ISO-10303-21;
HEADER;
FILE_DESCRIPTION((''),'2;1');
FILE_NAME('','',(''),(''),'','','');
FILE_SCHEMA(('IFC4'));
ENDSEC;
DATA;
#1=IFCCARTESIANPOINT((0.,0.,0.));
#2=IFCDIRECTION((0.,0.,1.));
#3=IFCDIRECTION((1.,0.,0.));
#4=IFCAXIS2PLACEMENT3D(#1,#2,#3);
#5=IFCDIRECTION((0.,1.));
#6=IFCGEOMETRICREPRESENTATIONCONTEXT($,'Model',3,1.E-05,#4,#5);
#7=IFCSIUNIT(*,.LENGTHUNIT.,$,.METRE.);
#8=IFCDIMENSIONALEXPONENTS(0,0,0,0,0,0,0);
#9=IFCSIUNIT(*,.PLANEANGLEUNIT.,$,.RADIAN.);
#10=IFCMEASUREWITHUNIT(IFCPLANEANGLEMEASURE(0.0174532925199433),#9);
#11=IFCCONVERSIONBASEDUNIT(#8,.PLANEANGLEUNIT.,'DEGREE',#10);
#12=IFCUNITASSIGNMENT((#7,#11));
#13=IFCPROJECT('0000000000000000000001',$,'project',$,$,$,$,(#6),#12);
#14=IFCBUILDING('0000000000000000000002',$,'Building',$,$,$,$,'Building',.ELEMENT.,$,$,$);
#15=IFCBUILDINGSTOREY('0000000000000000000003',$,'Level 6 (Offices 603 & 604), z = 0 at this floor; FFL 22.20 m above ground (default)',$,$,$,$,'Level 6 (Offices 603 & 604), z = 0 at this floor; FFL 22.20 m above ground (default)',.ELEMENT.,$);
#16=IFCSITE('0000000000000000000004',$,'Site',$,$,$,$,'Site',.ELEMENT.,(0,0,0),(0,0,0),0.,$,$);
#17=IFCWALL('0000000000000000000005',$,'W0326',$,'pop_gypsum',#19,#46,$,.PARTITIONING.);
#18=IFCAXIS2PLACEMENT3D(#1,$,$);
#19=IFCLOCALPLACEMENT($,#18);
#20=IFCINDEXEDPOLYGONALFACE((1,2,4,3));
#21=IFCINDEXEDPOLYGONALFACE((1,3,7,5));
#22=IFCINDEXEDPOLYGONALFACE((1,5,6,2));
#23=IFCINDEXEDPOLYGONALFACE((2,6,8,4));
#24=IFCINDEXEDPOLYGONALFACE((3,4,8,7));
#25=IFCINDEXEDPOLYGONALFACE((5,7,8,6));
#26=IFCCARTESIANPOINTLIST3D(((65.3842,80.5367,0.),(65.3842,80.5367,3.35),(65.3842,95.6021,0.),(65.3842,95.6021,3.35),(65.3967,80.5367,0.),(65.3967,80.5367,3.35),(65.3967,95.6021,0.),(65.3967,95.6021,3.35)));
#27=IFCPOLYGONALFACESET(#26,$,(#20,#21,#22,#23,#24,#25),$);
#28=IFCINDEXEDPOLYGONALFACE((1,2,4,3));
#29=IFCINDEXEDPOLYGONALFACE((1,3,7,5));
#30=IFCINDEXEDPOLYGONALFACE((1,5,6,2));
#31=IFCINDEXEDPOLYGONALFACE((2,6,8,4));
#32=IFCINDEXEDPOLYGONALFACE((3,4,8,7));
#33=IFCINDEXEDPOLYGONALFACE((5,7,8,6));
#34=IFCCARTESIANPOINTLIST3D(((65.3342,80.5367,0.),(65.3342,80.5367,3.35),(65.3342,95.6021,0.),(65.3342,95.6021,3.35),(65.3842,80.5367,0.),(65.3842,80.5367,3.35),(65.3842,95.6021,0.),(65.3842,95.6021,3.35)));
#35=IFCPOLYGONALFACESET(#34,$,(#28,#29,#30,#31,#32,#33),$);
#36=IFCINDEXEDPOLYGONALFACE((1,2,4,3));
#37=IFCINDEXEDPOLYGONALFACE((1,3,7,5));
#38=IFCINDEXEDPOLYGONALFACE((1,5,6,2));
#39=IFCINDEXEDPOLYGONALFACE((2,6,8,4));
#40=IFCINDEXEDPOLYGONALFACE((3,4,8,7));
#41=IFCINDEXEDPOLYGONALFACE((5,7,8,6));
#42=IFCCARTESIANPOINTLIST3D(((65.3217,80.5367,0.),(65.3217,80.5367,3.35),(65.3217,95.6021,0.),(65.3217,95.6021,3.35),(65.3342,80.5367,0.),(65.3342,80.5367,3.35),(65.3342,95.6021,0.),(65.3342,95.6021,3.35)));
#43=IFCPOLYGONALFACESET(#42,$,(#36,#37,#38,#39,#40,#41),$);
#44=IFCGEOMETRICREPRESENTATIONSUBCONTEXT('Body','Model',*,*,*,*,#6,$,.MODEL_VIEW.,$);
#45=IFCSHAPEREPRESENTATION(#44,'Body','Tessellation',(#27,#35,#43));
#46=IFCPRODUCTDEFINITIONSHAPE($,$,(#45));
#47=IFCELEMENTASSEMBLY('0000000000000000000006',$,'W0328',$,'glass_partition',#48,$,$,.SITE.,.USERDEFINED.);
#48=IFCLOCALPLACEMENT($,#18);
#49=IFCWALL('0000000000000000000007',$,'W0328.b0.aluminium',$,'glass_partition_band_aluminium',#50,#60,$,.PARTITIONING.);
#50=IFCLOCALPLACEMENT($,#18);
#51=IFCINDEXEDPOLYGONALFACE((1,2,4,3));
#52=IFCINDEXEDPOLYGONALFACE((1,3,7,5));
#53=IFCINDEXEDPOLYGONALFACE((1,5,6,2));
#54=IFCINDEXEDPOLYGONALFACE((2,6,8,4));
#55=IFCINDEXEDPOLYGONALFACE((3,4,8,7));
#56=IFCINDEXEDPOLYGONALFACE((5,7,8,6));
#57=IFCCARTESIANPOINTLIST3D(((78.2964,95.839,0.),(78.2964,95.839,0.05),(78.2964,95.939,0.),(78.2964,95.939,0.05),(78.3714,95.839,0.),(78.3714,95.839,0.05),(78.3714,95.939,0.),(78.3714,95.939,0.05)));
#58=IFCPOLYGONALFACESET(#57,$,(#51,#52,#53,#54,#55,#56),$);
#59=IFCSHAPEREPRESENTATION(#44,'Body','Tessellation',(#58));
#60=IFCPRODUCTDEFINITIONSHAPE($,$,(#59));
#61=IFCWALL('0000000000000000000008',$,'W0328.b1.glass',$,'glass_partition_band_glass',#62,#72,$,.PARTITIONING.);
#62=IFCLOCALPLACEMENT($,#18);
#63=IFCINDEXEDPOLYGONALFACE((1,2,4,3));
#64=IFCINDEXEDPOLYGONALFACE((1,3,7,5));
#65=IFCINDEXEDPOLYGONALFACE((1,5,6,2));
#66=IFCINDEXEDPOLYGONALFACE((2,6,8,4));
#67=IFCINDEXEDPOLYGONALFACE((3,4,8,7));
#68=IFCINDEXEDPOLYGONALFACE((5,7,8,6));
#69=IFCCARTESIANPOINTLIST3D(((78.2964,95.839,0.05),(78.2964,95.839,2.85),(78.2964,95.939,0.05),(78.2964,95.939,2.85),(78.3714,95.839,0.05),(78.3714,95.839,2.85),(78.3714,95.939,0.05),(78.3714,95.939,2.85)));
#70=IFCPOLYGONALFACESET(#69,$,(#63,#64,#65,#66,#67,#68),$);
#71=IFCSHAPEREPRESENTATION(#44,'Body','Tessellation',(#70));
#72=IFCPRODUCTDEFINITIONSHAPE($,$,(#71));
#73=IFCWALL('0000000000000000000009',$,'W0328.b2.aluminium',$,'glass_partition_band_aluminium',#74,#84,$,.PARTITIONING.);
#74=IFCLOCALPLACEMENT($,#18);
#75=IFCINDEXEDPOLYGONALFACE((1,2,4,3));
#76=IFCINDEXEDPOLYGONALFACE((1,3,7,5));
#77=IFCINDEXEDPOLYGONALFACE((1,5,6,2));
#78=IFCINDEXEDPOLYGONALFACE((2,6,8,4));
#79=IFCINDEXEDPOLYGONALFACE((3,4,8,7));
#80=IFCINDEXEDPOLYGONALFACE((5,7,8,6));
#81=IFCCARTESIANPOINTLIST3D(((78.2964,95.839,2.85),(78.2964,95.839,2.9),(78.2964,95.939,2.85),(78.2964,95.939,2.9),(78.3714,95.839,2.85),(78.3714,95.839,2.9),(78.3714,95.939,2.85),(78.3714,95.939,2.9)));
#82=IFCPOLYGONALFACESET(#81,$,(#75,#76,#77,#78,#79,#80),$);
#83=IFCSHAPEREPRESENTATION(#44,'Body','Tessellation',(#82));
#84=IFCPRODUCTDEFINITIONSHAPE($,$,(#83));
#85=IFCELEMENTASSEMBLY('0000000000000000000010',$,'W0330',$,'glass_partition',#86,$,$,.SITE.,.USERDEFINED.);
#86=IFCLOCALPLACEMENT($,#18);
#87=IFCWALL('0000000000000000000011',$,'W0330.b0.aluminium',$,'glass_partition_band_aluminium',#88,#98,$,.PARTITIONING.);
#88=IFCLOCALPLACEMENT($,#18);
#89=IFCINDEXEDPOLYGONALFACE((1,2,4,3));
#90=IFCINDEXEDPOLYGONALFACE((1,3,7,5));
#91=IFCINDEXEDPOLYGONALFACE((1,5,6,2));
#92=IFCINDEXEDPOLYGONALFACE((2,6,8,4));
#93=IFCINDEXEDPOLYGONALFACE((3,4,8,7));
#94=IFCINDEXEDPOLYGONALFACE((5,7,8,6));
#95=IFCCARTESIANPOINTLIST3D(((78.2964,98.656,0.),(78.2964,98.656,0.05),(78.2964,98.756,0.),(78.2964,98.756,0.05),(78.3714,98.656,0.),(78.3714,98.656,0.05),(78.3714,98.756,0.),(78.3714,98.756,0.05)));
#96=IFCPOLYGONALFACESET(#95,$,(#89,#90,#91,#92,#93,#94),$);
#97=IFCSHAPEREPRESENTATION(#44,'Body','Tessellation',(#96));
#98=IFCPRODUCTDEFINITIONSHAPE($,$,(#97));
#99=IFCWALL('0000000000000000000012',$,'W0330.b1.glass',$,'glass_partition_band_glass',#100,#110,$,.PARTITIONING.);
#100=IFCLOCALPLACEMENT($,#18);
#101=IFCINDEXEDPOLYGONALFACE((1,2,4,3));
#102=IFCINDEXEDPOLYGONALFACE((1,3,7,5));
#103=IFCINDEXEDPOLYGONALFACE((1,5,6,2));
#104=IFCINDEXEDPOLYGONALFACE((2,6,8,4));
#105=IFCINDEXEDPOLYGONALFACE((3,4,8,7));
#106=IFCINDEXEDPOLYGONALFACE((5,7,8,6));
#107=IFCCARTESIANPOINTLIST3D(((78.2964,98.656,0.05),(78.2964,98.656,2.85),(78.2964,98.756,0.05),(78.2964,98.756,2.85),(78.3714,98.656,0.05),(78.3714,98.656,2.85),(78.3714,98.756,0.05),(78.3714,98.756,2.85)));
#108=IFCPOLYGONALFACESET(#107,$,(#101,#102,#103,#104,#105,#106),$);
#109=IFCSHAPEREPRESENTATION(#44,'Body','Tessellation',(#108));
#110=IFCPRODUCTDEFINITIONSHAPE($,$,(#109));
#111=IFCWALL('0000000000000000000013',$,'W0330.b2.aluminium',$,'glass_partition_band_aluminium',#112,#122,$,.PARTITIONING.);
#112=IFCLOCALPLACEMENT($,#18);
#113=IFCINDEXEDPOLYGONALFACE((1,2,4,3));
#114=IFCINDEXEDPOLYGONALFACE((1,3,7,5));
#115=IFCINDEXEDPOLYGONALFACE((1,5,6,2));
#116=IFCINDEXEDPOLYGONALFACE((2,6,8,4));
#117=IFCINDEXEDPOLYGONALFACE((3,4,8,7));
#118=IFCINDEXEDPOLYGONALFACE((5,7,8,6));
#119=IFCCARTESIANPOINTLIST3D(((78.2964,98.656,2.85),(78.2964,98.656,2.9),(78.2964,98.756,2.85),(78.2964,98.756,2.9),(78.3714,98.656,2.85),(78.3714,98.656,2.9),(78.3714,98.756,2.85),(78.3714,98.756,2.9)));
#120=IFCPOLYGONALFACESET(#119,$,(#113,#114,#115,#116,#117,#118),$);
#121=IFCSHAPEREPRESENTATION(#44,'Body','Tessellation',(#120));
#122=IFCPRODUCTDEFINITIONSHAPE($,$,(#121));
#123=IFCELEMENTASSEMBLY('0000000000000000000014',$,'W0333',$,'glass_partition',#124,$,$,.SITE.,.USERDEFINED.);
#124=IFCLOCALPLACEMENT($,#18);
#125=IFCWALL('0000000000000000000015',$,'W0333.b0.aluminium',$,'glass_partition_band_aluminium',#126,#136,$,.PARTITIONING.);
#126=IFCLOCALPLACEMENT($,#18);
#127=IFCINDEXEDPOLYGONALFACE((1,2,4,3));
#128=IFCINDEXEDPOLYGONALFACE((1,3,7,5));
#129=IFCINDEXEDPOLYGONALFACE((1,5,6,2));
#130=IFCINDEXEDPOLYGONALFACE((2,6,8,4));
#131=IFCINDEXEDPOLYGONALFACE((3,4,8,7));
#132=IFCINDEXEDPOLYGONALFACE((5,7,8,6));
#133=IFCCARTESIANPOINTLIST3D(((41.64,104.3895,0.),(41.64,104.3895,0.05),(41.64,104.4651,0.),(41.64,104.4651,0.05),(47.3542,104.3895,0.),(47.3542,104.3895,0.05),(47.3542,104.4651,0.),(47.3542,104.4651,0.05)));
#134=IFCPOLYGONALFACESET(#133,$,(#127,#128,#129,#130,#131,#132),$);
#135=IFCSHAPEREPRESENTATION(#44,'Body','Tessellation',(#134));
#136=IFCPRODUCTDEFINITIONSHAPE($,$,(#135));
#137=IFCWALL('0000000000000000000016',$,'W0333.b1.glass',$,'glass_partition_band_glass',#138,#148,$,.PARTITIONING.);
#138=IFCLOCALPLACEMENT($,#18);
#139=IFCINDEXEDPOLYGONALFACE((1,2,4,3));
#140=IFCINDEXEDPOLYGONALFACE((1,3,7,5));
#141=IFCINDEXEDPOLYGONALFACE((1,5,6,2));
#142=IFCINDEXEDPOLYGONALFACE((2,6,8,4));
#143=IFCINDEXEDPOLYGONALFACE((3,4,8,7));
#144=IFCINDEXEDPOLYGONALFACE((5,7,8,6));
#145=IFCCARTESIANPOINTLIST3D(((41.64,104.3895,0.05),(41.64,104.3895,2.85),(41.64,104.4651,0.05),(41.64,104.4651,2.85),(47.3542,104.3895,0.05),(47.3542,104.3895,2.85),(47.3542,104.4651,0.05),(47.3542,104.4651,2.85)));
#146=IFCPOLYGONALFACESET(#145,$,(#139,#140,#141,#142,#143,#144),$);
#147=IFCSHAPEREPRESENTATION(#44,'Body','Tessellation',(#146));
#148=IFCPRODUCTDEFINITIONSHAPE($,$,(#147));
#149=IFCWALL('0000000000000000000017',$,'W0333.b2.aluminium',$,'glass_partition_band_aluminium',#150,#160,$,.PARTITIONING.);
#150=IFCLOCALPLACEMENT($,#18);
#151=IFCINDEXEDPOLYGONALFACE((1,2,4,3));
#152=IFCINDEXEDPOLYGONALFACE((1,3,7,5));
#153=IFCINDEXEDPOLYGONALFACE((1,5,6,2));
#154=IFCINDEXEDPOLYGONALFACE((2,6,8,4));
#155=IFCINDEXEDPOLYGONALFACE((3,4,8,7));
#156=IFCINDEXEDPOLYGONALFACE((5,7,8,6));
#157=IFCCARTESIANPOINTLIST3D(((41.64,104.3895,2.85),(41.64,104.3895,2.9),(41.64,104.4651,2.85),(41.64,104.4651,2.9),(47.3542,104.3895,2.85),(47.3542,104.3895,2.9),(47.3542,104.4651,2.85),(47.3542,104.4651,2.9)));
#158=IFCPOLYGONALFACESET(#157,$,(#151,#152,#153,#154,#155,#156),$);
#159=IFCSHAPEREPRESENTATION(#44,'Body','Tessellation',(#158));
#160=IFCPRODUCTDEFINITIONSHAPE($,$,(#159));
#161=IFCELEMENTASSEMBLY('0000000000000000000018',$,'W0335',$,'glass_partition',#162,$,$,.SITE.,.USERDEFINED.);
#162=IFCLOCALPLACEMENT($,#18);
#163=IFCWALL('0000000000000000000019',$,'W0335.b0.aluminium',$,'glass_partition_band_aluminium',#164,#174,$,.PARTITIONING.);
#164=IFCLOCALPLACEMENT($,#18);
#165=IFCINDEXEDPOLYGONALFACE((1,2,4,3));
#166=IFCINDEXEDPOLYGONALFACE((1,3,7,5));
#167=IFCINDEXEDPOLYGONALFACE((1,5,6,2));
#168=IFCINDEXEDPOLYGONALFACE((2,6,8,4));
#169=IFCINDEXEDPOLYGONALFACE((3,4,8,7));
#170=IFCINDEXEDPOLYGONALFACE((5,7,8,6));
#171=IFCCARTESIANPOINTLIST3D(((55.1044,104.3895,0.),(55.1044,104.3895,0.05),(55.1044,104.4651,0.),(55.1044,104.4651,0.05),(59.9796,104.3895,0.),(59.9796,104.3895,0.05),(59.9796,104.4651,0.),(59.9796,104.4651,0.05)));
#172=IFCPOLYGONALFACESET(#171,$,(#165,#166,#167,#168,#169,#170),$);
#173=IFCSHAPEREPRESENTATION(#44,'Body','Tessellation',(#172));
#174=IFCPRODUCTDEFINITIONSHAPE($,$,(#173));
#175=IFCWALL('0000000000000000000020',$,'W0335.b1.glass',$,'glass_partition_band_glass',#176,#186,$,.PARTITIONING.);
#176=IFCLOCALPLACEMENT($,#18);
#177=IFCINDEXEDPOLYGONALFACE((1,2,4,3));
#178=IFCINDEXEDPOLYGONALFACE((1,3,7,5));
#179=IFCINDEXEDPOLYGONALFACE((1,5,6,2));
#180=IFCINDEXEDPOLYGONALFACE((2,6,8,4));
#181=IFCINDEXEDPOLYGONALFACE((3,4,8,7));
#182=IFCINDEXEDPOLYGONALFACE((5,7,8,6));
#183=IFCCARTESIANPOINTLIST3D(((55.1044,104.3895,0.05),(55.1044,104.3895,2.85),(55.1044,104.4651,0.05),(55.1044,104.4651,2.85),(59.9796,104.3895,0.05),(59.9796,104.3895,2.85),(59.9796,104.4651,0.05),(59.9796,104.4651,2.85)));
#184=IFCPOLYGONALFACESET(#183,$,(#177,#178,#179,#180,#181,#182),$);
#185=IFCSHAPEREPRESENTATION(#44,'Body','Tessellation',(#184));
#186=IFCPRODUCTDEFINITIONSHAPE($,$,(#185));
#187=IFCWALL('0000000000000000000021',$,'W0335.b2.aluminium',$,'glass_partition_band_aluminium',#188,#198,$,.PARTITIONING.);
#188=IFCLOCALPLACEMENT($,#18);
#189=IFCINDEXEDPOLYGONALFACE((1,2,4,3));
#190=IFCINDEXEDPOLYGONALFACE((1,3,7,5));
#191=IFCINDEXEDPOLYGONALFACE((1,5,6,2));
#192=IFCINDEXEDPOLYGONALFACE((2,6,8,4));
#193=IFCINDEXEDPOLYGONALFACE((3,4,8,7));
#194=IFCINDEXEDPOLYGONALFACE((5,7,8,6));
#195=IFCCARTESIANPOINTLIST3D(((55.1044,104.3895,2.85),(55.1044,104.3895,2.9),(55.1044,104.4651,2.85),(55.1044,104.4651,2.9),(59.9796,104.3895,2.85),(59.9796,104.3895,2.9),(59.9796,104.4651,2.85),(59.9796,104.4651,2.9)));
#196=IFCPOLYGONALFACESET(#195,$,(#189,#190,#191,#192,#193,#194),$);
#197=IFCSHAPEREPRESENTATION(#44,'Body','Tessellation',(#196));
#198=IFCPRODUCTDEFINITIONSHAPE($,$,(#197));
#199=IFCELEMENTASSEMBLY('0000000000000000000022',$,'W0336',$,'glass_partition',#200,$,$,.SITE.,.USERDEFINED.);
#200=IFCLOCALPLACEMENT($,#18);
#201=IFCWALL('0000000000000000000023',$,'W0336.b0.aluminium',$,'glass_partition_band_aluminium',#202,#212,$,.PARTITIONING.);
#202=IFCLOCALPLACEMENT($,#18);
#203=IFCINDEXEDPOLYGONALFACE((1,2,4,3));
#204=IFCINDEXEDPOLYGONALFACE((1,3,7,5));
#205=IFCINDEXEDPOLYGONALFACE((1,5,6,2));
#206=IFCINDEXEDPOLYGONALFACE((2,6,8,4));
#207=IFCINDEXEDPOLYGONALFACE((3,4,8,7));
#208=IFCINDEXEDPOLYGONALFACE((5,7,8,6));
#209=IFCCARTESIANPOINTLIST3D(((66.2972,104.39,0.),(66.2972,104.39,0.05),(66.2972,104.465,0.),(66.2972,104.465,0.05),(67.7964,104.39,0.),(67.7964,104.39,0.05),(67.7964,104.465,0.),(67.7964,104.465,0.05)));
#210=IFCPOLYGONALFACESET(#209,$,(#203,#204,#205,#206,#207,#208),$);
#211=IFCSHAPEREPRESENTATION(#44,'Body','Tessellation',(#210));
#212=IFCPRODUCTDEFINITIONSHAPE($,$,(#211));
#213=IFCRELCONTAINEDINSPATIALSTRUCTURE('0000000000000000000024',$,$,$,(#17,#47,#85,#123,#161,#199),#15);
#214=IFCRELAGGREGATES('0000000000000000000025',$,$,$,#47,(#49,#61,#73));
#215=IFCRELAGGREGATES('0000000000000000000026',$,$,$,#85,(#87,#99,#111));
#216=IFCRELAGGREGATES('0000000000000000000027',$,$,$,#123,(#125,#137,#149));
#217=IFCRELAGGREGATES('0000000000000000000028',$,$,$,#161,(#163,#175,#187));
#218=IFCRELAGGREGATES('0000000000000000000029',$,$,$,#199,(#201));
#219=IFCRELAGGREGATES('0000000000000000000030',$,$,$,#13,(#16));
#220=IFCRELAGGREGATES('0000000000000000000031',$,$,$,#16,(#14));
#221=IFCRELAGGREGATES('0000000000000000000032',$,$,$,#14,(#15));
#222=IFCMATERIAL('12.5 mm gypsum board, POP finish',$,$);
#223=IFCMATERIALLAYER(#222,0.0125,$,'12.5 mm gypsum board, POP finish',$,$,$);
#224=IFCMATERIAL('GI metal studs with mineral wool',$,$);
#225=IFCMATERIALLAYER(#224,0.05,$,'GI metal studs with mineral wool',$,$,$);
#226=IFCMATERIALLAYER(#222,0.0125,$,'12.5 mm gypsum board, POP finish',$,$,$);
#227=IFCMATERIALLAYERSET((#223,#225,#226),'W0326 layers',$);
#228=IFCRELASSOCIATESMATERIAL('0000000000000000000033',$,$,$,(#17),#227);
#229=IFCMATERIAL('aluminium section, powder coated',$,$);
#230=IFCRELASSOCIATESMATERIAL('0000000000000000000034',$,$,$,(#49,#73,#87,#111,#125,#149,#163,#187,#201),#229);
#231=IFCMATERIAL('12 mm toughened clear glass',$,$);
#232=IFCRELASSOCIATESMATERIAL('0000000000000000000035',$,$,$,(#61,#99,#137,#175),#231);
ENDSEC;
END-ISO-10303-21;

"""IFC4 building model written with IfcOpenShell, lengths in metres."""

from ifc_helpers import new_model, entity, si_unit, converted_unit, direction, frame, frame_2d, origin_with_axes, place, context, subcontext, project, spatial, rectangle, extrude, material, layer, layer_set, layer_usage, element, aggregate, save


model = new_model("IFC4")

# Units and contexts
model_context = context("Model", 3, precision=1e-05, world=origin_with_axes(), true_north=direction((0.0, 1.0)))
body_context = subcontext(model_context, "Body", "Model", "MODEL_VIEW")
ifc_project = project(units=[si_unit("LENGTHUNIT", "METRE"), converted_unit("PLANEANGLEUNIT", "DEGREE", entity("IfcPlaneAngleMeasure", 0.0174532925199433), si_unit("PLANEANGLEUNIT", "RADIAN"), dimensions=[0, 0, 0, 0, 0, 0, 0])], contexts=[model_context])

# Site, building, storey
site = spatial("IfcSite", under=ifc_project, Name="Site", LongName="Site", CompositionType="ELEMENT", RefLatitude=(0, 0, 0), RefLongitude=(0, 0, 0), RefElevation=0.0)
building = spatial("IfcBuilding", under=site, Name="Building", LongName="Building", CompositionType="ELEMENT")
storey = spatial("IfcBuildingStorey", under=building, Name="Level 6 (Offices 603 & 604), z = 0 at this floor; FFL 22.20 m above ground (default)", LongName="Level 6 (Offices 603 & 604), z = 0 at this floor; FFL 22.20 m above ground (default)", CompositionType="ELEMENT")

# Wall
placement = place(None, origin_with_axes())
ifc_material_1 = material(Name="12.5 mm gypsum board, POP finish")
ifc_material_2 = material(Name="GI metal studs with mineral wool")
ifc_layer_1 = layer(ifc_material_1, 0.0125, Name="12.5 mm gypsum board, POP finish")
ifc_layer_2 = layer(ifc_material_2, 0.05, Name="GI metal studs with mineral wool")
ifc_layer_3 = layer(ifc_material_1, 0.0125, Name="12.5 mm gypsum board, POP finish")
ifc_layer_set_1 = layer_set([ifc_layer_1, ifc_layer_2, ifc_layer_3], Name="W0326 layers")
ifc_layer_usage_1 = layer_usage(ifc_layer_set_1, "AXIS2", "POSITIVE", -0.0375)
element("IfcWall", 1, at=placement, inside=storey, material=ifc_layer_usage_1, Name="W0326", ObjectType="pop_gypsum", PredefinedType="PARTITIONING", context=body_context, shape_type="SweptSolid", body=[
    extrude(rectangle(XDim=15.0654, YDim=0.0125, at=frame_2d((0.0, 0.0), x_axis=(0.0, 1.0))), frame((65.3905, 88.0694, 0.0), z_axis=(0.0, 0.0, 1.0), x_axis=(1.0, 0.0, 0.0)), (0.0, 0.0, 1.0), 3.35),
    extrude(rectangle(XDim=15.0654, YDim=0.05, at=frame_2d((-0.0312, 0.0), x_axis=(0.0, 1.0))), frame((65.3905, 88.0694, 0.0), z_axis=(0.0, 0.0, 1.0), x_axis=(1.0, 0.0, 0.0)), (0.0, 0.0, 1.0), 3.35),
    extrude(rectangle(XDim=15.0654, YDim=0.0125, at=frame_2d((-0.0625, 0.0), x_axis=(0.0, 1.0))), frame((65.3905, 88.0694, 0.0), z_axis=(0.0, 0.0, 1.0), x_axis=(1.0, 0.0, 0.0)), (0.0, 0.0, 1.0), 3.35),
])

# Element assemblies, walls
assembly_1 = element("IfcElementAssembly", 2, inside=storey, Name="W0328", ObjectType="glass_partition", AssemblyPlace="SITE", PredefinedType="USERDEFINED")
ifc_material_3 = material(Name="aluminium section, powder coated")
wall_1 = element("IfcWall", 3, at=placement, material=ifc_material_3, Name="W0328.b0.aluminium", ObjectType="glass_partition_band_aluminium", PredefinedType="PARTITIONING", context=body_context, shape_type="SweptSolid", body=[
    extrude(rectangle(XDim=0.1, YDim=0.075, at=frame_2d((0.0, 0.0), x_axis=(0.0, 1.0))), frame((78.3339, 95.889, 0.0), z_axis=(0.0, 0.0, 1.0), x_axis=(1.0, 0.0, 0.0)), (0.0, 0.0, 1.0), 0.05),
])
ifc_material_4 = material(Name="12 mm toughened clear glass")
wall_2 = element("IfcWall", 4, at=placement, material=ifc_material_4, Name="W0328.b1.glass", ObjectType="glass_partition_band_glass", PredefinedType="PARTITIONING", context=body_context, shape_type="SweptSolid", body=[
    extrude(rectangle(XDim=0.1, YDim=0.075, at=frame_2d((0.0, 0.0), x_axis=(0.0, 1.0))), frame((78.3339, 95.889, 0.05), z_axis=(0.0, 0.0, 1.0), x_axis=(1.0, 0.0, 0.0)), (0.0, 0.0, 1.0), 2.8),
])
wall_3 = element("IfcWall", 5, at=placement, material=ifc_material_3, Name="W0328.b2.aluminium", ObjectType="glass_partition_band_aluminium", PredefinedType="PARTITIONING", context=body_context, shape_type="SweptSolid", body=[
    extrude(rectangle(XDim=0.1, YDim=0.075, at=frame_2d((0.0, 0.0), x_axis=(0.0, 1.0))), frame((78.3339, 95.889, 2.85), z_axis=(0.0, 0.0, 1.0), x_axis=(1.0, 0.0, 0.0)), (0.0, 0.0, 1.0), 0.05),
])
aggregate(assembly_1, [wall_1, wall_2, wall_3])
assembly_2 = element("IfcElementAssembly", 6, inside=storey, Name="W0330", ObjectType="glass_partition", AssemblyPlace="SITE", PredefinedType="USERDEFINED")
wall_4 = element("IfcWall", 7, at=placement, material=ifc_material_3, Name="W0330.b0.aluminium", ObjectType="glass_partition_band_aluminium", PredefinedType="PARTITIONING", context=body_context, shape_type="SweptSolid", body=[
    extrude(rectangle(XDim=0.1, YDim=0.075, at=frame_2d((0.0, 0.0), x_axis=(0.0, 1.0))), frame((78.3339, 98.706, 0.0), z_axis=(0.0, 0.0, 1.0), x_axis=(1.0, 0.0, 0.0)), (0.0, 0.0, 1.0), 0.05),
])
wall_5 = element("IfcWall", 8, at=placement, material=ifc_material_4, Name="W0330.b1.glass", ObjectType="glass_partition_band_glass", PredefinedType="PARTITIONING", context=body_context, shape_type="SweptSolid", body=[
    extrude(rectangle(XDim=0.1, YDim=0.075, at=frame_2d((0.0, 0.0), x_axis=(0.0, 1.0))), frame((78.3339, 98.706, 0.05), z_axis=(0.0, 0.0, 1.0), x_axis=(1.0, 0.0, 0.0)), (0.0, 0.0, 1.0), 2.8),
])
wall_6 = element("IfcWall", 9, at=placement, material=ifc_material_3, Name="W0330.b2.aluminium", ObjectType="glass_partition_band_aluminium", PredefinedType="PARTITIONING", context=body_context, shape_type="SweptSolid", body=[
    extrude(rectangle(XDim=0.1, YDim=0.075, at=frame_2d((0.0, 0.0), x_axis=(0.0, 1.0))), frame((78.3339, 98.706, 2.85), z_axis=(0.0, 0.0, 1.0), x_axis=(1.0, 0.0, 0.0)), (0.0, 0.0, 1.0), 0.05),
])
aggregate(assembly_2, [wall_4, wall_5, wall_6])
assembly_3 = element("IfcElementAssembly", 10, inside=storey, Name="W0333", ObjectType="glass_partition", AssemblyPlace="SITE", PredefinedType="USERDEFINED")
wall_7 = element("IfcWall", 11, at=placement, material=ifc_material_3, Name="W0333.b0.aluminium", ObjectType="glass_partition_band_aluminium", PredefinedType="PARTITIONING", context=body_context, shape_type="SweptSolid", body=[
    extrude(rectangle(XDim=5.7142, YDim=0.0756, at=frame_2d((0.0, 0.0), x_axis=(1.0, 0.0))), frame((44.4971, 104.4273, 0.0), z_axis=(0.0, 0.0, 1.0), x_axis=(1.0, 0.0, 0.0)), (0.0, 0.0, 1.0), 0.05),
])
wall_8 = element("IfcWall", 12, at=placement, material=ifc_material_4, Name="W0333.b1.glass", ObjectType="glass_partition_band_glass", PredefinedType="PARTITIONING", context=body_context, shape_type="SweptSolid", body=[
    extrude(rectangle(XDim=5.7142, YDim=0.0756, at=frame_2d((0.0, 0.0), x_axis=(1.0, 0.0))), frame((44.4971, 104.4273, 0.05), z_axis=(0.0, 0.0, 1.0), x_axis=(1.0, 0.0, 0.0)), (0.0, 0.0, 1.0), 2.8),
])
wall_9 = element("IfcWall", 13, at=placement, material=ifc_material_3, Name="W0333.b2.aluminium", ObjectType="glass_partition_band_aluminium", PredefinedType="PARTITIONING", context=body_context, shape_type="SweptSolid", body=[
    extrude(rectangle(XDim=5.7142, YDim=0.0756, at=frame_2d((0.0, 0.0), x_axis=(1.0, 0.0))), frame((44.4971, 104.4273, 2.85), z_axis=(0.0, 0.0, 1.0), x_axis=(1.0, 0.0, 0.0)), (0.0, 0.0, 1.0), 0.05),
])
aggregate(assembly_3, [wall_7, wall_8, wall_9])
assembly_4 = element("IfcElementAssembly", 14, inside=storey, Name="W0335", ObjectType="glass_partition", AssemblyPlace="SITE", PredefinedType="USERDEFINED")
wall_10 = element("IfcWall", 15, at=placement, material=ifc_material_3, Name="W0335.b0.aluminium", ObjectType="glass_partition_band_aluminium", PredefinedType="PARTITIONING", context=body_context, shape_type="SweptSolid", body=[
    extrude(rectangle(XDim=4.8752, YDim=0.0756, at=frame_2d((0.0, 0.0), x_axis=(1.0, 0.0))), frame((57.542, 104.4273, 0.0), z_axis=(0.0, 0.0, 1.0), x_axis=(1.0, 0.0, 0.0)), (0.0, 0.0, 1.0), 0.05),
])
wall_11 = element("IfcWall", 16, at=placement, material=ifc_material_4, Name="W0335.b1.glass", ObjectType="glass_partition_band_glass", PredefinedType="PARTITIONING", context=body_context, shape_type="SweptSolid", body=[
    extrude(rectangle(XDim=4.8752, YDim=0.0756, at=frame_2d((0.0, 0.0), x_axis=(1.0, 0.0))), frame((57.542, 104.4273, 0.05), z_axis=(0.0, 0.0, 1.0), x_axis=(1.0, 0.0, 0.0)), (0.0, 0.0, 1.0), 2.8),
])
wall_12 = element("IfcWall", 17, at=placement, material=ifc_material_3, Name="W0335.b2.aluminium", ObjectType="glass_partition_band_aluminium", PredefinedType="PARTITIONING", context=body_context, shape_type="SweptSolid", body=[
    extrude(rectangle(XDim=4.8752, YDim=0.0756, at=frame_2d((0.0, 0.0), x_axis=(1.0, 0.0))), frame((57.542, 104.4273, 2.85), z_axis=(0.0, 0.0, 1.0), x_axis=(1.0, 0.0, 0.0)), (0.0, 0.0, 1.0), 0.05),
])
aggregate(assembly_4, [wall_10, wall_11, wall_12])
assembly_5 = element("IfcElementAssembly", 18, inside=storey, Name="W0336", ObjectType="glass_partition", AssemblyPlace="SITE", PredefinedType="USERDEFINED")
wall_13 = element("IfcWall", 19, at=placement, material=ifc_material_3, Name="W0336.b0.aluminium", ObjectType="glass_partition_band_aluminium", PredefinedType="PARTITIONING", context=body_context, shape_type="SweptSolid", body=[
    extrude(rectangle(XDim=1.4992, YDim=0.075, at=frame_2d((0.0, 0.0), x_axis=(1.0, 0.0))), frame((67.0468, 104.4275, 0.0), z_axis=(0.0, 0.0, 1.0), x_axis=(1.0, 0.0, 0.0)), (0.0, 0.0, 1.0), 0.05),
])
aggregate(assembly_5, [wall_13])

save(model, "model.ifc")
